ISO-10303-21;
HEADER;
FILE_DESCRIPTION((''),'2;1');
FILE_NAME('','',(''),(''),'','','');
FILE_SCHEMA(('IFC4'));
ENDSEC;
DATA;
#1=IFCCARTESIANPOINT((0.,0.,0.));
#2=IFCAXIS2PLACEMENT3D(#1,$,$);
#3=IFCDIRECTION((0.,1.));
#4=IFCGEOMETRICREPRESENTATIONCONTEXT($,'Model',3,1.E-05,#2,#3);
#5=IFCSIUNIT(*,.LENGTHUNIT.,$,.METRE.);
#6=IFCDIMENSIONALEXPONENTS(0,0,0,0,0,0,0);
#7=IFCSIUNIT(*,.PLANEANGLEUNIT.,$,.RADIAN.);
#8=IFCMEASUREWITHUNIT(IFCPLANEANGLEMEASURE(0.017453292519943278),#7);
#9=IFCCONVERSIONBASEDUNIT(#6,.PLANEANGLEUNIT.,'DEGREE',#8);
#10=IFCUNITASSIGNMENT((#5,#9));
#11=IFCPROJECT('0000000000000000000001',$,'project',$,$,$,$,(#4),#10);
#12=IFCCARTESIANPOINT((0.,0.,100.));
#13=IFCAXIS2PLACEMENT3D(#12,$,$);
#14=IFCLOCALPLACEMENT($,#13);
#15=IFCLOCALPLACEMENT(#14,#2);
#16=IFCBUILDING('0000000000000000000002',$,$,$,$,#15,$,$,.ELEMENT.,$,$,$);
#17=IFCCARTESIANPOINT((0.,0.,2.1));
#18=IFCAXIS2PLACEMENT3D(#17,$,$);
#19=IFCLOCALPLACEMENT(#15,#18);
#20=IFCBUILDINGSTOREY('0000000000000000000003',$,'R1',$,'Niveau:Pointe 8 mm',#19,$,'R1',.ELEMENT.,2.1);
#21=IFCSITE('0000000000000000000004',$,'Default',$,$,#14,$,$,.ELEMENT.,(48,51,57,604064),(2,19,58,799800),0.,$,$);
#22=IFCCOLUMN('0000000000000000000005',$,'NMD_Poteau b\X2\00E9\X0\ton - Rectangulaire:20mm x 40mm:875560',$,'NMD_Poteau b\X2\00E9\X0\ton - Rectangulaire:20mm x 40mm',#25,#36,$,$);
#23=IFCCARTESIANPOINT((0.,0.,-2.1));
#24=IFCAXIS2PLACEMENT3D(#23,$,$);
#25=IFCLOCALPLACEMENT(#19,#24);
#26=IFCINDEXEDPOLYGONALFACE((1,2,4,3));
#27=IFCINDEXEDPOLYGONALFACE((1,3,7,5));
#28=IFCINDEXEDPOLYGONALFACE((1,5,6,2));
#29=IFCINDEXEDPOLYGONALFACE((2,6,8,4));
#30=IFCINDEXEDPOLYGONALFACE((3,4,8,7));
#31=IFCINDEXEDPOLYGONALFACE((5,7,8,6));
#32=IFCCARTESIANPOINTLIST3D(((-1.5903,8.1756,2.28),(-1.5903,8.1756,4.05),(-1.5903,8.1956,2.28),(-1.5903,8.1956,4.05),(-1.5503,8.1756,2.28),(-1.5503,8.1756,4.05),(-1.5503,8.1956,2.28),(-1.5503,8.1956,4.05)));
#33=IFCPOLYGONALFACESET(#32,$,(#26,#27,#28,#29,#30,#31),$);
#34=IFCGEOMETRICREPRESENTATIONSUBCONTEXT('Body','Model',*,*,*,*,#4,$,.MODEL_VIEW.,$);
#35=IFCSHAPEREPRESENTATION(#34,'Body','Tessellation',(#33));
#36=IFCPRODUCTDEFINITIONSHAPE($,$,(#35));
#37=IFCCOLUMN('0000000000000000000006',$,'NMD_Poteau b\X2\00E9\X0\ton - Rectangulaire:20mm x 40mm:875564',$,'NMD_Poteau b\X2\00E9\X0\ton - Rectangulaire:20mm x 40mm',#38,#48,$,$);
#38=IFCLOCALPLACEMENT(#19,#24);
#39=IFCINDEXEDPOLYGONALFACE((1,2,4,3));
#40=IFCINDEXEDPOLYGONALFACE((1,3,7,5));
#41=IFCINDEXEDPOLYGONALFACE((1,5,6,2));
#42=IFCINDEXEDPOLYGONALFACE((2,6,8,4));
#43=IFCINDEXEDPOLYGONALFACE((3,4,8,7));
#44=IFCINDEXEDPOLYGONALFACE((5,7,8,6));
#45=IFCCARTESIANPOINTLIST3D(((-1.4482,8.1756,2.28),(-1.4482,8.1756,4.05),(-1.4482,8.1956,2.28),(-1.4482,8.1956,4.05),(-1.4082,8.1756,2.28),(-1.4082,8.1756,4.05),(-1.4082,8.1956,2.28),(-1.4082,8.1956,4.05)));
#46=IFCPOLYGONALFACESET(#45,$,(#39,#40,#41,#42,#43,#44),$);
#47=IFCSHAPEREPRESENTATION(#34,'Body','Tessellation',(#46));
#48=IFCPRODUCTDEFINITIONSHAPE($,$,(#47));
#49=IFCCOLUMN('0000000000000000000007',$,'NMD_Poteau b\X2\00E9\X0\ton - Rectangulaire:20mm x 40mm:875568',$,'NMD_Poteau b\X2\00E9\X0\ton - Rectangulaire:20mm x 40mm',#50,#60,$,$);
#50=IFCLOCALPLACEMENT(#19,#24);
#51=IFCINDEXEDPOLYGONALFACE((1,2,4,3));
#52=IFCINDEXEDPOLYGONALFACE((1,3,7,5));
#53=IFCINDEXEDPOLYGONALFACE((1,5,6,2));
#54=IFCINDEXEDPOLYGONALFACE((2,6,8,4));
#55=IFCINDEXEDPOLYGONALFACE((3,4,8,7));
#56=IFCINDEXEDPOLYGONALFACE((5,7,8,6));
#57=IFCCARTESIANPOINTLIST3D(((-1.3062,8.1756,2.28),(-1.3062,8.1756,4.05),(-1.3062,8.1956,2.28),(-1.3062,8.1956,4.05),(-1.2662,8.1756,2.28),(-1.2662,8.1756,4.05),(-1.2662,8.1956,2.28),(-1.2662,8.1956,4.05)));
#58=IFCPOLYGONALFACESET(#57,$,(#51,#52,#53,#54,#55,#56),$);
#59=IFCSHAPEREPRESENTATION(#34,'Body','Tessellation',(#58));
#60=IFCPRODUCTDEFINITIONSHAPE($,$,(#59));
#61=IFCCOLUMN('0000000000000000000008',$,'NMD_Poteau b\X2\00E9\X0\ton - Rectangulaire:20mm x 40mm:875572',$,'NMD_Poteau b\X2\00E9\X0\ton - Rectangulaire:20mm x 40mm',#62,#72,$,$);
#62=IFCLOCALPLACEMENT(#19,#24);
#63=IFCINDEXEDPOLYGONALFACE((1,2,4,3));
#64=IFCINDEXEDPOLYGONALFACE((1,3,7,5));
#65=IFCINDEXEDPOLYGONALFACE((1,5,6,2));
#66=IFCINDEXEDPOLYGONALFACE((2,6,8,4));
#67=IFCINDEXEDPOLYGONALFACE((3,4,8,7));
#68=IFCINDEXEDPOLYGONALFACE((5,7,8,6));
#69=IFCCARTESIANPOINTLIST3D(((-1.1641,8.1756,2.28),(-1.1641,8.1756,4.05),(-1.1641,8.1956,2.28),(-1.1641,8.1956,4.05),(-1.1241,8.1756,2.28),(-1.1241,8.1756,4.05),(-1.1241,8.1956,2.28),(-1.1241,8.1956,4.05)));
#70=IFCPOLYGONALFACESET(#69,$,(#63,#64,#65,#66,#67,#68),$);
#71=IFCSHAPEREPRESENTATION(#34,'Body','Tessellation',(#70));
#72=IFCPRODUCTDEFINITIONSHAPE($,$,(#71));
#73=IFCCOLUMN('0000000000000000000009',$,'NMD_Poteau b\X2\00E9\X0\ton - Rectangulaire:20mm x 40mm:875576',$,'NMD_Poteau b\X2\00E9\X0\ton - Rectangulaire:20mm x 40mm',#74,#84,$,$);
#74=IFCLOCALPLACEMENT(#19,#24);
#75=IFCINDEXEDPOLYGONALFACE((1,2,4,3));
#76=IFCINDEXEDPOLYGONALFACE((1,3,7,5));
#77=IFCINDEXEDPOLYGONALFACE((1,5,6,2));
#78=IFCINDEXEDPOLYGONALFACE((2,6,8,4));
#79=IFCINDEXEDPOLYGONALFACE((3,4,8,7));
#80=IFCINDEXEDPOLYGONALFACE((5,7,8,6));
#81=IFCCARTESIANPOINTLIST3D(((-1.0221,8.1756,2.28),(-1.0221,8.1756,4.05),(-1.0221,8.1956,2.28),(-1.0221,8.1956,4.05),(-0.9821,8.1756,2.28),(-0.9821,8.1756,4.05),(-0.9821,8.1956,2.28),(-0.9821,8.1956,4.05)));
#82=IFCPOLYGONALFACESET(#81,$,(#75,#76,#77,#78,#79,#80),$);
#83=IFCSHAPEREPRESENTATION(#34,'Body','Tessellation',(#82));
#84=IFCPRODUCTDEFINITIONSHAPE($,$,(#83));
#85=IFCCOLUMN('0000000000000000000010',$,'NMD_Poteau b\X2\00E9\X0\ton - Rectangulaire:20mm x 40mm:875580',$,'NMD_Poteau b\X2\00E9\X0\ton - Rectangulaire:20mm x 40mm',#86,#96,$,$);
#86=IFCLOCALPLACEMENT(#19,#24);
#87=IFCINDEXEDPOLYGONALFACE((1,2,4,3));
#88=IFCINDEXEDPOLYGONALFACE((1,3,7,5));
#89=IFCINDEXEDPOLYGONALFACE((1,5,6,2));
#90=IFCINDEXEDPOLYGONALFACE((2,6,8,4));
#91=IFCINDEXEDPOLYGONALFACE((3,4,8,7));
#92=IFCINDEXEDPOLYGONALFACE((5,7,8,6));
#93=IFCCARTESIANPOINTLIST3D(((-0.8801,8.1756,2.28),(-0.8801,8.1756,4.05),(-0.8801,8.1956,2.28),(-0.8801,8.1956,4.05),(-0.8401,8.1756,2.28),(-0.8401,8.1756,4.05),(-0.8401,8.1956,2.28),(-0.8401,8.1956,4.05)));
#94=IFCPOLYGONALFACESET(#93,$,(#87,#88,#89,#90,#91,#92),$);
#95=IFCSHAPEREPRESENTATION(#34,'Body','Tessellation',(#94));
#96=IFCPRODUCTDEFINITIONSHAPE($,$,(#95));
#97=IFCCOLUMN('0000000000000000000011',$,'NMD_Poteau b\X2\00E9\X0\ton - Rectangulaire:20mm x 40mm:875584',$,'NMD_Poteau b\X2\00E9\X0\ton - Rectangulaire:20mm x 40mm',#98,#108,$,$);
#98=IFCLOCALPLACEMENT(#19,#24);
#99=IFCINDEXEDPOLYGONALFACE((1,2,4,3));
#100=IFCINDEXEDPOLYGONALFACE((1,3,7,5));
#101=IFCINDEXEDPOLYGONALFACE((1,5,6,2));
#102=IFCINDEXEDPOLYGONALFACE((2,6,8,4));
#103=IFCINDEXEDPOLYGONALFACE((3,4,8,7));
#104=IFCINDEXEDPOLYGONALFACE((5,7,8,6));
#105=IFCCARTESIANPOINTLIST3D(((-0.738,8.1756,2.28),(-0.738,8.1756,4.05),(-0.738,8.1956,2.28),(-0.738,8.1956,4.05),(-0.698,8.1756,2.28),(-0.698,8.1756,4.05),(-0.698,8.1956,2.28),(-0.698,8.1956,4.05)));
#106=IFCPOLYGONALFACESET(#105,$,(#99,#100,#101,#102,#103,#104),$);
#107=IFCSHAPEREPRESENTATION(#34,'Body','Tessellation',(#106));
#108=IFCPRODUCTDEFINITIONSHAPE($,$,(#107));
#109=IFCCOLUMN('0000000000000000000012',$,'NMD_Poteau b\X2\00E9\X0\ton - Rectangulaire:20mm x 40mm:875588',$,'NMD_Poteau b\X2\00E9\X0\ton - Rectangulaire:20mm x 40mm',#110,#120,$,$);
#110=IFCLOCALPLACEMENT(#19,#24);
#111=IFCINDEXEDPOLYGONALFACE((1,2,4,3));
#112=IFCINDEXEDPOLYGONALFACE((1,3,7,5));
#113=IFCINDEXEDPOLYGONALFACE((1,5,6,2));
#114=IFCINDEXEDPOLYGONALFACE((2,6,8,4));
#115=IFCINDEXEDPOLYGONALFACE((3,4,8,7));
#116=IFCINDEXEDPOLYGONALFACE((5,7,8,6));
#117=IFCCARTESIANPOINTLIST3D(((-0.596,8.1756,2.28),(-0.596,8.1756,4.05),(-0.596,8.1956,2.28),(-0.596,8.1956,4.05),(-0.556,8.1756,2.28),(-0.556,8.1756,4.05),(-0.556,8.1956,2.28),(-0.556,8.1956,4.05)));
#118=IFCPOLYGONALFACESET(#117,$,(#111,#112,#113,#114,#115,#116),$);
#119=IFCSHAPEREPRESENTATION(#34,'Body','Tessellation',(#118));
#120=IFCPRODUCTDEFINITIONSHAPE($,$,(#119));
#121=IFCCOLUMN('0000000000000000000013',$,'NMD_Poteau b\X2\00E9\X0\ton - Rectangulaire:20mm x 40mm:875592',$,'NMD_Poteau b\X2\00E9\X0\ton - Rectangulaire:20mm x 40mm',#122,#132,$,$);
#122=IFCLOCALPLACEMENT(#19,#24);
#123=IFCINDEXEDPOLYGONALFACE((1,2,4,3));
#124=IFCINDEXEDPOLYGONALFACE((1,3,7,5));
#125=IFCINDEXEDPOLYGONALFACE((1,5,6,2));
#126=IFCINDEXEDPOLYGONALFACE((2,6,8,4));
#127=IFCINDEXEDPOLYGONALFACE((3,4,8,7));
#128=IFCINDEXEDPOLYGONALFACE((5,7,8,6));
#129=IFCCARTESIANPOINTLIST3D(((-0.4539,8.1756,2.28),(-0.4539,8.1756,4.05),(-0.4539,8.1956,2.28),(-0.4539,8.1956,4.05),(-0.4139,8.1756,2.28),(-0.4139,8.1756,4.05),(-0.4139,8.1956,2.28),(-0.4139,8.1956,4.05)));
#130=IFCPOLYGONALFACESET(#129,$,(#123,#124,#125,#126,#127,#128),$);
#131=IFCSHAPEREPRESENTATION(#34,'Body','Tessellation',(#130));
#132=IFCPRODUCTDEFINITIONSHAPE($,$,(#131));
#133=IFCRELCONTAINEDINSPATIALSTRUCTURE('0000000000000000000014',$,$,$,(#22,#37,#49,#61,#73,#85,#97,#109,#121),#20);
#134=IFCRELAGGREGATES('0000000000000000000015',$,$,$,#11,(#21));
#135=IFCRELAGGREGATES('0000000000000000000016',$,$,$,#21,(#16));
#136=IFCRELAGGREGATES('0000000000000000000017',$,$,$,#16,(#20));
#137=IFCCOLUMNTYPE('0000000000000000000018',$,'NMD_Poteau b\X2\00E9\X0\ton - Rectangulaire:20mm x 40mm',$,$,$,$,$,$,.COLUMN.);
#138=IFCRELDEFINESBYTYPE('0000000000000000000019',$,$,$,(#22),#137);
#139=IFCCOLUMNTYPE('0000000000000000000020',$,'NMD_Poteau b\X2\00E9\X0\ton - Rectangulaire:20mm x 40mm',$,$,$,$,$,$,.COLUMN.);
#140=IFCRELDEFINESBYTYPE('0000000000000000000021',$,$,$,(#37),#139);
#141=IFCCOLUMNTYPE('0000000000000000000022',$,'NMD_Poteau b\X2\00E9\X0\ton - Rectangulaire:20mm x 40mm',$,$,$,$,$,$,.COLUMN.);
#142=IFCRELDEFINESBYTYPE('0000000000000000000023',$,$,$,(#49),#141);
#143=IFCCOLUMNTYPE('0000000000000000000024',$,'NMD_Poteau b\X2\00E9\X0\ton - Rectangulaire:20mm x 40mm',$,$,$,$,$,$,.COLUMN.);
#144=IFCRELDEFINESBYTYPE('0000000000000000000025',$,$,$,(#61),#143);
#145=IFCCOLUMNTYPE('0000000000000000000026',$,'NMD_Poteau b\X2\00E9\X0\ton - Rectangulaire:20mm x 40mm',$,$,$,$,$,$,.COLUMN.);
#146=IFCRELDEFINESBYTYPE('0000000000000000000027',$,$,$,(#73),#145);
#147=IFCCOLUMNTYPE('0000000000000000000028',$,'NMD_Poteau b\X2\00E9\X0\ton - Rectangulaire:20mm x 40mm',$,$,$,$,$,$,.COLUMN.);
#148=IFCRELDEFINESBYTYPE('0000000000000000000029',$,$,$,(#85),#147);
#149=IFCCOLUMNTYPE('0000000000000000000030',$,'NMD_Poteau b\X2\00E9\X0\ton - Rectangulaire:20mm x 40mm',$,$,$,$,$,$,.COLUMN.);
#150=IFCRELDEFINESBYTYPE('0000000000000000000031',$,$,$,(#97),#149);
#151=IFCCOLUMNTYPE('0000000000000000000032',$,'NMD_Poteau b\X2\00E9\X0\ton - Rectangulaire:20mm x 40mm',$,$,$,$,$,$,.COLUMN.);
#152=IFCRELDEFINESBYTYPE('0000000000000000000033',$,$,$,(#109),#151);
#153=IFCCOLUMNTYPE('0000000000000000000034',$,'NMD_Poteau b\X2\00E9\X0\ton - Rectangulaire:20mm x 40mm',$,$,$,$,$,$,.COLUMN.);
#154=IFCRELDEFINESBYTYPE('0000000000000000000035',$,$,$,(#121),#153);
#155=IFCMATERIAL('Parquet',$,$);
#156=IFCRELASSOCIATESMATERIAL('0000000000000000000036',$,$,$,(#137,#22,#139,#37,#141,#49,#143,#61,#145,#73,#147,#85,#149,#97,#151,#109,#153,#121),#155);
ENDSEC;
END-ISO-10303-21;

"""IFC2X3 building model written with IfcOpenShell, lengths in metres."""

from ifc_helpers import new_model, entity, si_unit, converted_unit, direction, frame, frame_2d, origin, origin_2d_with_axis, place, context, subcontext, project, spatial, rectangle, extrude, source, transform, mapped, material, type_object, type_shapes, element, save


model = new_model("IFC2X3")

# Units and contexts
model_context = context("Model", 3, precision=1e-05, world=origin(), true_north=direction((0.0, 1.0)))
body_context = subcontext(model_context, "Body", "Model", "MODEL_VIEW")
ifc_project = project(units=[si_unit("LENGTHUNIT", "METRE"), converted_unit("PLANEANGLEUNIT", "DEGREE", entity("IfcPlaneAngleMeasure", 0.017453292519943278), si_unit("PLANEANGLEUNIT", "RADIAN"), dimensions=[0, 0, 0, 0, 0, 0, 0])], contexts=[model_context])

# Site, building, storey
site_placement = place(None, frame((0.0, 0.0, 100.0)))
site = spatial("IfcSite", under=ifc_project, at=site_placement, Name="Default", CompositionType="ELEMENT", RefLatitude=(48, 51, 57, 604064), RefLongitude=(2, 19, 58, 799800), RefElevation=0.0)
building_placement = place(site_placement, origin())
building = spatial("IfcBuilding", under=site, at=building_placement, CompositionType="ELEMENT")
storey_placement = place(building_placement, frame((0.0, 0.0, 2.1)))
storey = spatial("IfcBuildingStorey", under=building, at=storey_placement, Name="R1", ObjectType="Niveau:Pointe 8 mm", LongName="R1", CompositionType="ELEMENT", Elevation=2.1)

# Columns
ifc_material_1 = material(Name="Parquet")
column_type_1 = type_object("IfcColumnType", Name="NMD_Poteau béton - Rectangulaire:20mm x 40mm", PredefinedType="COLUMN", material=ifc_material_1)
shared_shape_1 = source(origin(), body_context, "Body", "SweptSolid", [
    extrude(rectangle(XDim=0.02, YDim=0.04, at=origin_2d_with_axis()), frame((-1.5703, 8.1856, 2.28), z_axis=(0.0, 0.0, 1.0), x_axis=(0.0, -1.0, 0.0)), (0.0, 0.0, 1.0), 1.77),
])
type_shapes(column_type_1, [shared_shape_1])
column_1_placement = place(storey_placement, frame((0.0, 0.0, -2.1)))
element("IfcColumn", 1, at=column_1_placement, inside=storey, type_object=column_type_1, material=ifc_material_1, Name="NMD_Poteau béton - Rectangulaire:20mm x 40mm:875560", ObjectType="NMD_Poteau béton - Rectangulaire:20mm x 40mm", context=body_context, shape_type="MappedRepresentation", body=[
    mapped(shared_shape_1, transform((0.0, 0.0, 0.0), scale=1.0)),
])
column_type_2 = type_object("IfcColumnType", Name="NMD_Poteau béton - Rectangulaire:20mm x 40mm", PredefinedType="COLUMN", material=ifc_material_1)
shared_shape_2 = source(origin(), body_context, "Body", "SweptSolid", [
    extrude(rectangle(XDim=0.02, YDim=0.04, at=origin_2d_with_axis()), frame((-1.4282, 8.1856, 2.28), z_axis=(0.0, 0.0, 1.0), x_axis=(0.0, -1.0, 0.0)), (0.0, 0.0, 1.0), 1.77),
])
type_shapes(column_type_2, [shared_shape_2])
column_2_placement = place(storey_placement, frame((0.0, 0.0, -2.1)))
element("IfcColumn", 2, at=column_2_placement, inside=storey, type_object=column_type_2, material=ifc_material_1, Name="NMD_Poteau béton - Rectangulaire:20mm x 40mm:875564", ObjectType="NMD_Poteau béton - Rectangulaire:20mm x 40mm", context=body_context, shape_type="MappedRepresentation", body=[
    mapped(shared_shape_2, transform((0.0, 0.0, 0.0), scale=1.0)),
])
column_type_3 = type_object("IfcColumnType", Name="NMD_Poteau béton - Rectangulaire:20mm x 40mm", PredefinedType="COLUMN", material=ifc_material_1)
shared_shape_3 = source(origin(), body_context, "Body", "SweptSolid", [
    extrude(rectangle(XDim=0.02, YDim=0.04, at=origin_2d_with_axis()), frame((-1.2862, 8.1856, 2.28), z_axis=(0.0, 0.0, 1.0), x_axis=(0.0, -1.0, 0.0)), (0.0, 0.0, 1.0), 1.77),
])
type_shapes(column_type_3, [shared_shape_3])
column_3_placement = place(storey_placement, frame((0.0, 0.0, -2.1)))
element("IfcColumn", 3, at=column_3_placement, inside=storey, type_object=column_type_3, material=ifc_material_1, Name="NMD_Poteau béton - Rectangulaire:20mm x 40mm:875568", ObjectType="NMD_Poteau béton - Rectangulaire:20mm x 40mm", context=body_context, shape_type="MappedRepresentation", body=[
    mapped(shared_shape_3, transform((0.0, 0.0, 0.0), scale=1.0)),
])
column_type_4 = type_object("IfcColumnType", Name="NMD_Poteau béton - Rectangulaire:20mm x 40mm", PredefinedType="COLUMN", material=ifc_material_1)
shared_shape_4 = source(origin(), body_context, "Body", "SweptSolid", [
    extrude(rectangle(XDim=0.02, YDim=0.04, at=frame_2d((0.0, 0.0), x_axis=(1.0, 0.0))), frame((-1.1441, 8.1856, 2.28), z_axis=(0.0, 0.0, 1.0), x_axis=(0.0, -1.0, 0.0)), (0.0, 0.0, 1.0), 1.77),
])
type_shapes(column_type_4, [shared_shape_4])
column_4_placement = place(storey_placement, frame((0.0, 0.0, -2.1)))
element("IfcColumn", 4, at=column_4_placement, inside=storey, type_object=column_type_4, material=ifc_material_1, Name="NMD_Poteau béton - Rectangulaire:20mm x 40mm:875572", ObjectType="NMD_Poteau béton - Rectangulaire:20mm x 40mm", context=body_context, shape_type="MappedRepresentation", body=[
    mapped(shared_shape_4, transform((0.0, 0.0, 0.0), scale=1.0)),
])
column_type_5 = type_object("IfcColumnType", Name="NMD_Poteau béton - Rectangulaire:20mm x 40mm", PredefinedType="COLUMN", material=ifc_material_1)
shared_shape_5 = source(origin(), body_context, "Body", "SweptSolid", [
    extrude(rectangle(XDim=0.02, YDim=0.04, at=frame_2d((0.0, 0.0), x_axis=(1.0, 0.0))), frame((-1.0021, 8.1856, 2.28), z_axis=(0.0, 0.0, 1.0), x_axis=(0.0, -1.0, 0.0)), (0.0, 0.0, 1.0), 1.77),
])
type_shapes(column_type_5, [shared_shape_5])
column_5_placement = place(storey_placement, frame((0.0, 0.0, -2.1)))
element("IfcColumn", 5, at=column_5_placement, inside=storey, type_object=column_type_5, material=ifc_material_1, Name="NMD_Poteau béton - Rectangulaire:20mm x 40mm:875576", ObjectType="NMD_Poteau béton - Rectangulaire:20mm x 40mm", context=body_context, shape_type="MappedRepresentation", body=[
    mapped(shared_shape_5, transform((0.0, 0.0, 0.0), scale=1.0)),
])
column_type_6 = type_object("IfcColumnType", Name="NMD_Poteau béton - Rectangulaire:20mm x 40mm", PredefinedType="COLUMN", material=ifc_material_1)
shared_shape_6 = source(origin(), body_context, "Body", "SweptSolid", [
    extrude(rectangle(XDim=0.02, YDim=0.04, at=frame_2d((0.0, 0.0), x_axis=(1.0, 0.0))), frame((-0.8601, 8.1856, 2.28), z_axis=(0.0, 0.0, 1.0), x_axis=(0.0, -1.0, 0.0)), (0.0, 0.0, 1.0), 1.77),
])
type_shapes(column_type_6, [shared_shape_6])
column_6_placement = place(storey_placement, frame((0.0, 0.0, -2.1)))
element("IfcColumn", 6, at=column_6_placement, inside=storey, type_object=column_type_6, material=ifc_material_1, Name="NMD_Poteau béton - Rectangulaire:20mm x 40mm:875580", ObjectType="NMD_Poteau béton - Rectangulaire:20mm x 40mm", context=body_context, shape_type="MappedRepresentation", body=[
    mapped(shared_shape_6, transform((0.0, 0.0, 0.0), scale=1.0)),
])
column_type_7 = type_object("IfcColumnType", Name="NMD_Poteau béton - Rectangulaire:20mm x 40mm", PredefinedType="COLUMN", material=ifc_material_1)
shared_shape_7 = source(origin(), body_context, "Body", "SweptSolid", [
    extrude(rectangle(XDim=0.02, YDim=0.04, at=frame_2d((0.0, 0.0), x_axis=(1.0, 0.0))), frame((-0.718, 8.1856, 2.28), z_axis=(0.0, 0.0, 1.0), x_axis=(0.0, -1.0, 0.0)), (0.0, 0.0, 1.0), 1.77),
])
type_shapes(column_type_7, [shared_shape_7])
column_7_placement = place(storey_placement, frame((0.0, 0.0, -2.1)))
element("IfcColumn", 7, at=column_7_placement, inside=storey, type_object=column_type_7, material=ifc_material_1, Name="NMD_Poteau béton - Rectangulaire:20mm x 40mm:875584", ObjectType="NMD_Poteau béton - Rectangulaire:20mm x 40mm", context=body_context, shape_type="MappedRepresentation", body=[
    mapped(shared_shape_7, transform((0.0, 0.0, 0.0), scale=1.0)),
])
column_type_8 = type_object("IfcColumnType", Name="NMD_Poteau béton - Rectangulaire:20mm x 40mm", PredefinedType="COLUMN", material=ifc_material_1)
shared_shape_8 = source(origin(), body_context, "Body", "SweptSolid", [
    extrude(rectangle(XDim=0.02, YDim=0.04, at=frame_2d((0.0, 0.0), x_axis=(1.0, 0.0))), frame((-0.576, 8.1856, 2.28), z_axis=(0.0, 0.0, 1.0), x_axis=(0.0, -1.0, 0.0)), (0.0, 0.0, 1.0), 1.77),
])
type_shapes(column_type_8, [shared_shape_8])
column_8_placement = place(storey_placement, frame((0.0, 0.0, -2.1)))
element("IfcColumn", 8, at=column_8_placement, inside=storey, type_object=column_type_8, material=ifc_material_1, Name="NMD_Poteau béton - Rectangulaire:20mm x 40mm:875588", ObjectType="NMD_Poteau béton - Rectangulaire:20mm x 40mm", context=body_context, shape_type="MappedRepresentation", body=[
    mapped(shared_shape_8, transform((0.0, 0.0, 0.0), scale=1.0)),
])
column_type_9 = type_object("IfcColumnType", Name="NMD_Poteau béton - Rectangulaire:20mm x 40mm", PredefinedType="COLUMN", material=ifc_material_1)
shared_shape_9 = source(origin(), body_context, "Body", "SweptSolid", [
    extrude(rectangle(XDim=0.02, YDim=0.04, at=frame_2d((0.0, 0.0), x_axis=(1.0, 0.0))), frame((-0.4339, 8.1856, 2.28), z_axis=(0.0, 0.0, 1.0), x_axis=(0.0, -1.0, 0.0)), (0.0, 0.0, 1.0), 1.77),
])
type_shapes(column_type_9, [shared_shape_9])
column_9_placement = place(storey_placement, frame((0.0, 0.0, -2.1)))
element("IfcColumn", 9, at=column_9_placement, inside=storey, type_object=column_type_9, material=ifc_material_1, Name="NMD_Poteau béton - Rectangulaire:20mm x 40mm:875592", ObjectType="NMD_Poteau béton - Rectangulaire:20mm x 40mm", context=body_context, shape_type="MappedRepresentation", body=[
    mapped(shared_shape_9, transform((0.0, 0.0, 0.0), scale=1.0)),
])

save(model, "model.ifc")
